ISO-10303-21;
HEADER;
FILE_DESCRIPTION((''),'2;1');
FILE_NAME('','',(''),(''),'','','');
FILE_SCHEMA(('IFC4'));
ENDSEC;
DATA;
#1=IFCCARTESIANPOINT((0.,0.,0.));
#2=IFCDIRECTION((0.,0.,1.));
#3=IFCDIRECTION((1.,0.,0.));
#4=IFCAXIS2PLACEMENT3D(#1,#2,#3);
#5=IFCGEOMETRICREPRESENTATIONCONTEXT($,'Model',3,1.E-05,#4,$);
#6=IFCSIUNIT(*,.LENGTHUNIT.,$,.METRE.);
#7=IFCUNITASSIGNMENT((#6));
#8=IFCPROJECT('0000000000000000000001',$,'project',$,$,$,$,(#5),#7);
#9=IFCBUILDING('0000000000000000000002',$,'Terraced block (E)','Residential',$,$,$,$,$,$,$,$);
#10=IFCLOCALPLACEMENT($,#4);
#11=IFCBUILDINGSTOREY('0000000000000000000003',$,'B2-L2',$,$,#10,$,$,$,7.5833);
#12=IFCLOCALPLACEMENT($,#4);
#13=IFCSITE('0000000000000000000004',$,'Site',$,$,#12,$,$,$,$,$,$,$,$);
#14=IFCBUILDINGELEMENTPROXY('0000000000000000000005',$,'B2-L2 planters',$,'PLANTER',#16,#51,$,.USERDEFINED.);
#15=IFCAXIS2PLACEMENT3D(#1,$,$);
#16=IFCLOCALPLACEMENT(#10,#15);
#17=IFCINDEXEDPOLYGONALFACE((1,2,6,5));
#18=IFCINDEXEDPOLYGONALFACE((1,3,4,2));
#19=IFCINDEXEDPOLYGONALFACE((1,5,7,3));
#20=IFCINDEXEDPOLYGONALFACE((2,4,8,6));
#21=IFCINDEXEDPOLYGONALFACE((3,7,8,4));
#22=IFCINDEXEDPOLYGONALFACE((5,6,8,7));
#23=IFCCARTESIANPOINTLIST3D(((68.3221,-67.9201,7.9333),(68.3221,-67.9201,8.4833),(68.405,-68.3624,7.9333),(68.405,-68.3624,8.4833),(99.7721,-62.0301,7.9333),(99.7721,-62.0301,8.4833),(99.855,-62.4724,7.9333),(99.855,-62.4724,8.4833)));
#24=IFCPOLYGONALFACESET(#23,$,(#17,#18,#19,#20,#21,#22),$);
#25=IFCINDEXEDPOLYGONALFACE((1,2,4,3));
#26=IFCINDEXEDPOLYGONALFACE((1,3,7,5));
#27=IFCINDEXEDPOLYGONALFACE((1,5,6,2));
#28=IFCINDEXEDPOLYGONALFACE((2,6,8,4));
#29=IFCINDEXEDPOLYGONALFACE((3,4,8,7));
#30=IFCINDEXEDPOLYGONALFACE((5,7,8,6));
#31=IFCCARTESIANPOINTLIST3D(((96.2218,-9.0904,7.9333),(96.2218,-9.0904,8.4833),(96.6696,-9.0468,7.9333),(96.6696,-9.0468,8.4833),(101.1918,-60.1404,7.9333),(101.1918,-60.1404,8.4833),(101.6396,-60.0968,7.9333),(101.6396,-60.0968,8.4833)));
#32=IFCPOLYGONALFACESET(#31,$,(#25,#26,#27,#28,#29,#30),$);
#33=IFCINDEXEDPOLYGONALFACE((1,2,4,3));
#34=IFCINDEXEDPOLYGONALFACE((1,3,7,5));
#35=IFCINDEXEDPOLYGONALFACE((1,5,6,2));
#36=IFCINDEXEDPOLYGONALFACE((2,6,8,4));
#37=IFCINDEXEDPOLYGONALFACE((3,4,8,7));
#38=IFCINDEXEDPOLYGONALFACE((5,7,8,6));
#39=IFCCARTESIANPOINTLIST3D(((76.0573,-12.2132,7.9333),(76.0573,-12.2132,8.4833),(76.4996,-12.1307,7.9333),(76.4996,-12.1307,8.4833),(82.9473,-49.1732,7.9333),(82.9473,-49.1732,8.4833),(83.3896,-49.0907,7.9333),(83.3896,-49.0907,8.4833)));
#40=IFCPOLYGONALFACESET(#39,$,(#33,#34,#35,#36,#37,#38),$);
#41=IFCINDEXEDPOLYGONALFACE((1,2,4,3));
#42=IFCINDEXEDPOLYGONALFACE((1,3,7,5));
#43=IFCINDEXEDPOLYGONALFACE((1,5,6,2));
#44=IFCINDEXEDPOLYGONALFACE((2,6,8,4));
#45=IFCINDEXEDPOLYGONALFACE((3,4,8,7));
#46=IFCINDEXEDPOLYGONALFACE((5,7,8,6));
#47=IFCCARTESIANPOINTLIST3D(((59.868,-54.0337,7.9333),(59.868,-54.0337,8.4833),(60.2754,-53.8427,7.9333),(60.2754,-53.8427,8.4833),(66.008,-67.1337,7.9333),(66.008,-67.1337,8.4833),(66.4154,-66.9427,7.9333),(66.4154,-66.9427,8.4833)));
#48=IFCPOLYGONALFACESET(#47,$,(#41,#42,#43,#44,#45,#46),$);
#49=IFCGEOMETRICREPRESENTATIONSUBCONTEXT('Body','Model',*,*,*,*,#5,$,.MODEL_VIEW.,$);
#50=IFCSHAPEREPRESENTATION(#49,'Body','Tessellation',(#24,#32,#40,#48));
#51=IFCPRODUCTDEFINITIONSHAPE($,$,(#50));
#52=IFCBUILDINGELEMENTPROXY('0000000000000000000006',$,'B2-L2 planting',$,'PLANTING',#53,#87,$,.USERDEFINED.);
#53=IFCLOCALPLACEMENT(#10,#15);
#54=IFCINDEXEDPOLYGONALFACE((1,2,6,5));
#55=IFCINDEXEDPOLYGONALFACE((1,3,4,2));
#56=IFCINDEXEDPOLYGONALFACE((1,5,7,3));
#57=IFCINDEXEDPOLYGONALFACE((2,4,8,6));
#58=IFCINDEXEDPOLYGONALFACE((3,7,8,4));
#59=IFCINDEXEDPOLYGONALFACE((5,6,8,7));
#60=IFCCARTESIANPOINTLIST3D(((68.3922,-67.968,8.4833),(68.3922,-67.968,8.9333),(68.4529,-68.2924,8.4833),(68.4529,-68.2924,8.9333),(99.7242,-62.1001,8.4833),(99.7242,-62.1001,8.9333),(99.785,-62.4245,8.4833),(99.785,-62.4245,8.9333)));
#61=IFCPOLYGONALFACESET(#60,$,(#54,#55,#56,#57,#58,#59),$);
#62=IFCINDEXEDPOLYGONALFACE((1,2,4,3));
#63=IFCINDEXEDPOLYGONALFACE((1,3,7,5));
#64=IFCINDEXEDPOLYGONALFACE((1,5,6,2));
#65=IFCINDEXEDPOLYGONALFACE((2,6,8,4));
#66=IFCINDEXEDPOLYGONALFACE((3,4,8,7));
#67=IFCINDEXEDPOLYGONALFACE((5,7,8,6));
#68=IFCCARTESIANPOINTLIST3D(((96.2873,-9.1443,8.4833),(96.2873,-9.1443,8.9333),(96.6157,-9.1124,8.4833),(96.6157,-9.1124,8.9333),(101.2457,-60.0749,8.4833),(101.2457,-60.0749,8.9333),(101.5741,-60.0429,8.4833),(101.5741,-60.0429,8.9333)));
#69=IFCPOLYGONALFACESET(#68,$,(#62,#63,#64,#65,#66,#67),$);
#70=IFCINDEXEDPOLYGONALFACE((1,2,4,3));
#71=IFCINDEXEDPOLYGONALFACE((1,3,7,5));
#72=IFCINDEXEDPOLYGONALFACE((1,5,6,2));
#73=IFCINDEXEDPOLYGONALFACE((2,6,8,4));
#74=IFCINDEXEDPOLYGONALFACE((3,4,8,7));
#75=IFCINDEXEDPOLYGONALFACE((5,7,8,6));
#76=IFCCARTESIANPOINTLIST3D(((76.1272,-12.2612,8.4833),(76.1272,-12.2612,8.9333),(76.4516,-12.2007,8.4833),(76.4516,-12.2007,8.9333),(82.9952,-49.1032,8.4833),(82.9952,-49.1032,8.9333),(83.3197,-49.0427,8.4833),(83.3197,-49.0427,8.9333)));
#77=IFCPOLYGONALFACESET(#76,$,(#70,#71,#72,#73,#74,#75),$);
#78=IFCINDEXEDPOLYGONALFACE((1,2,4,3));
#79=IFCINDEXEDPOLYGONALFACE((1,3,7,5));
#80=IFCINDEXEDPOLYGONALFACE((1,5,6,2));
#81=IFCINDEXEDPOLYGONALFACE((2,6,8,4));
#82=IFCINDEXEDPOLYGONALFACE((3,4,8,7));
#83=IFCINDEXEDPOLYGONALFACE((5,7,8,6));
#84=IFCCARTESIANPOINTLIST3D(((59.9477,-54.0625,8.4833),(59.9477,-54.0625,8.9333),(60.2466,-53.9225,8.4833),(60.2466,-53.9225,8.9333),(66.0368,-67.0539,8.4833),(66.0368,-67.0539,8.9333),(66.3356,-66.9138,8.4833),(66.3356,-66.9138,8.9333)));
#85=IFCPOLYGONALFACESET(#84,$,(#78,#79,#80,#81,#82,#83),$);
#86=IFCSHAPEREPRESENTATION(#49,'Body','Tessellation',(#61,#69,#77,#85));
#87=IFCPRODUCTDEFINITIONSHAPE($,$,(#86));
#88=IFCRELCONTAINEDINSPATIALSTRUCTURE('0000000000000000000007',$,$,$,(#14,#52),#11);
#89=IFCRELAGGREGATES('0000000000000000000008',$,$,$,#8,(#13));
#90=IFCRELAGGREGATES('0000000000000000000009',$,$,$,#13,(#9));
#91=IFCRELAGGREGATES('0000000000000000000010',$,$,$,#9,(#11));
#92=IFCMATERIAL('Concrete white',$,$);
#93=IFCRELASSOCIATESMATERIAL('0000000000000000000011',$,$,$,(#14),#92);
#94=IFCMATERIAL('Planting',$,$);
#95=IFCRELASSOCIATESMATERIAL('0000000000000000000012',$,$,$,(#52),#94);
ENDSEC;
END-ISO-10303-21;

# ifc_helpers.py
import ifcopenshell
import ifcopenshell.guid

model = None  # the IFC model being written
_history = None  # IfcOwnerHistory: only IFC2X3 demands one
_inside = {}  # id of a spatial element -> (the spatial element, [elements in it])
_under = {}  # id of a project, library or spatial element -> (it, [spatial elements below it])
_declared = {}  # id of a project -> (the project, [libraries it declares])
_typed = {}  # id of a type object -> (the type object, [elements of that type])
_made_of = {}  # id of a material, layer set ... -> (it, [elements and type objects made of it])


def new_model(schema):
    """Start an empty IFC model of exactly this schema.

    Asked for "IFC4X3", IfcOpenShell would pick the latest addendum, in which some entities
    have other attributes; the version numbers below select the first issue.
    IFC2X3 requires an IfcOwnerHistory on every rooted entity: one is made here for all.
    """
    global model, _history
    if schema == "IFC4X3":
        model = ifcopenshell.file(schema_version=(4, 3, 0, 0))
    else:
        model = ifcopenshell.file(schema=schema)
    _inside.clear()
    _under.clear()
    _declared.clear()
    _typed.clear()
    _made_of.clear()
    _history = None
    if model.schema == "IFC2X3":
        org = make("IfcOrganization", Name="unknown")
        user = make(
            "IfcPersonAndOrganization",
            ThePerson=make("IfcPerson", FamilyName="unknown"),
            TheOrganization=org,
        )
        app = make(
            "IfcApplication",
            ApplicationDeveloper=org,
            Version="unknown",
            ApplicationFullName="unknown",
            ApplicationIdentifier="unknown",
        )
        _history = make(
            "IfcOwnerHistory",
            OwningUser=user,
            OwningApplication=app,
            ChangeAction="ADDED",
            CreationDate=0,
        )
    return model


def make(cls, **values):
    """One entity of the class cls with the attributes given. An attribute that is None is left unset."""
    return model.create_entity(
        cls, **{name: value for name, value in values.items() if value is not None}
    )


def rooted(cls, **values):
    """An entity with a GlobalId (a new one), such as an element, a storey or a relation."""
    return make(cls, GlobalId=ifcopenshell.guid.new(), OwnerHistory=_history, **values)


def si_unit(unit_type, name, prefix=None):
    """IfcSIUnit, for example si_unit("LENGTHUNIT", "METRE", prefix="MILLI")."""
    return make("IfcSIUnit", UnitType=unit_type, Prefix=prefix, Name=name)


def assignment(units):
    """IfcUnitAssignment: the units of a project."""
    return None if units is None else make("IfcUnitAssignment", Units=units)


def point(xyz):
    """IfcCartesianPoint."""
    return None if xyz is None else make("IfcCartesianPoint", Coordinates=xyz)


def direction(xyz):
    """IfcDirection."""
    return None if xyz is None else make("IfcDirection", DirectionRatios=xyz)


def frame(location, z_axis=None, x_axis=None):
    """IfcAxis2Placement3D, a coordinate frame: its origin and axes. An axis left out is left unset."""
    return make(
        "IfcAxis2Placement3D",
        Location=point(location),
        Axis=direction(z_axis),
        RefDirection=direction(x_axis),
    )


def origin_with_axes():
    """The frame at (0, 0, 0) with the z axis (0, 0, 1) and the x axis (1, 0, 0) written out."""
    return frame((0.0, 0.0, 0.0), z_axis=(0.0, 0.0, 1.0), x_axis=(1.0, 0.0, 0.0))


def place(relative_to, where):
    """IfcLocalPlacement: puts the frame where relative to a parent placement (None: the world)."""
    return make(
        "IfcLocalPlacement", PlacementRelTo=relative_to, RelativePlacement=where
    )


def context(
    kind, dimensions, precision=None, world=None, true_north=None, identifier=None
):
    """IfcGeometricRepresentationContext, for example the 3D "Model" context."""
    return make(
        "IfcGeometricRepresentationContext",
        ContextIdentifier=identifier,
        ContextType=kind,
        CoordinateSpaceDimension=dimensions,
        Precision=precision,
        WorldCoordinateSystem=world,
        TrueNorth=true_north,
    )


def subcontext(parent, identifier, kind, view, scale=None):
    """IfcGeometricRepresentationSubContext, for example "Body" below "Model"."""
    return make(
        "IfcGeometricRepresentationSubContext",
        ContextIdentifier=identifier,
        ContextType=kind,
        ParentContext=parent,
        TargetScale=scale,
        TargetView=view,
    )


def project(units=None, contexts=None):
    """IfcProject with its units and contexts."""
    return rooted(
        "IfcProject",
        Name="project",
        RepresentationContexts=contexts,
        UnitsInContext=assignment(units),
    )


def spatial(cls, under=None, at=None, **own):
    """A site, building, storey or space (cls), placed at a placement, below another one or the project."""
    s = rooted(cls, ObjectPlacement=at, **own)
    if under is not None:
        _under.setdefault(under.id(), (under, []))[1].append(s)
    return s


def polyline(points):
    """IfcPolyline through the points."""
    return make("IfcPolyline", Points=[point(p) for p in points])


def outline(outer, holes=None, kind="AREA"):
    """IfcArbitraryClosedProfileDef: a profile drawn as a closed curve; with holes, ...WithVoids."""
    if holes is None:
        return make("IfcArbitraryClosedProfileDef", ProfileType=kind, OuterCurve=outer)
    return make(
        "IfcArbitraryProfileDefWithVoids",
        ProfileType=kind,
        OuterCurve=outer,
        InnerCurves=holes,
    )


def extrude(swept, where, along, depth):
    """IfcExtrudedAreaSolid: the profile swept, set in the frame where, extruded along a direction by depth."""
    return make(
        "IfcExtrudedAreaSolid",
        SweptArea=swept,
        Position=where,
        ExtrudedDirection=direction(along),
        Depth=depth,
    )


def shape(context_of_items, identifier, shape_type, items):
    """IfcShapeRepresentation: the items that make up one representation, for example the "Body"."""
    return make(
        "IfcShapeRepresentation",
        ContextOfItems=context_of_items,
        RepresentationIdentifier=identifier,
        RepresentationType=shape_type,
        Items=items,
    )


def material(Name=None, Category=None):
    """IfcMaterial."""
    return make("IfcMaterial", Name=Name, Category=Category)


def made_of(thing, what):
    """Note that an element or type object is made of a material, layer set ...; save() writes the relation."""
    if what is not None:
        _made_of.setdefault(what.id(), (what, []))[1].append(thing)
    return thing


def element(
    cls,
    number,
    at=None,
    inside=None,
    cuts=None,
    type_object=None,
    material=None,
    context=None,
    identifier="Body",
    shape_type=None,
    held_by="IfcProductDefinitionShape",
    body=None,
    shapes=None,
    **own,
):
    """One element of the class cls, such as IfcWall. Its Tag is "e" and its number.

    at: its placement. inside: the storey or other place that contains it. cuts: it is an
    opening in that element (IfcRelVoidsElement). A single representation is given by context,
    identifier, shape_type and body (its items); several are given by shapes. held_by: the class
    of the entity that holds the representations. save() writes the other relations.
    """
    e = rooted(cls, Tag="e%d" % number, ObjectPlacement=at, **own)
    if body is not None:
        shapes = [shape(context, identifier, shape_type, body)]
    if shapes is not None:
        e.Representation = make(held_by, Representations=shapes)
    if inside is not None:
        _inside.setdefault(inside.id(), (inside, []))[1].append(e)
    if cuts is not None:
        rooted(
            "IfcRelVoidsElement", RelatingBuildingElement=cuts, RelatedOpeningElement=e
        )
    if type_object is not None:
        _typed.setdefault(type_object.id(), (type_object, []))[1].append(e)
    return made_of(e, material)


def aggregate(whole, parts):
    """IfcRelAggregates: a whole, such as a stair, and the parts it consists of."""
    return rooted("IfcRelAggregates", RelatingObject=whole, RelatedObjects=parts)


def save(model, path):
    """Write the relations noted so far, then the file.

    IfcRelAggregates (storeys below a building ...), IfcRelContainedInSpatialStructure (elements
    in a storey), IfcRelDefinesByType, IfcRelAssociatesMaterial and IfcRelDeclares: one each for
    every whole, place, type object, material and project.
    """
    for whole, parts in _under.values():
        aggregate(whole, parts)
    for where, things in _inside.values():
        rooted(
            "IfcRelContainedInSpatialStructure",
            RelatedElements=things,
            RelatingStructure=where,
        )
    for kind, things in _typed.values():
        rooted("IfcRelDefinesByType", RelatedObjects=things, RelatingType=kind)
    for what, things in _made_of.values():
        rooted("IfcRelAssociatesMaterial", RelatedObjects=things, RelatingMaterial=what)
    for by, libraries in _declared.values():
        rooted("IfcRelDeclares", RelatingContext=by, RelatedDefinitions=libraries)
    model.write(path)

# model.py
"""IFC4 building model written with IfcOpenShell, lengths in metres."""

from ifc_helpers import new_model, si_unit, frame, origin_with_axes, place, context, subcontext, project, spatial, polyline, outline, extrude, material, element, save


model = new_model("IFC4")

# Units and contexts
model_context = context("Model", 3, precision=1e-05, world=origin_with_axes())
body_context = subcontext(model_context, "Body", "Model", "MODEL_VIEW")
ifc_project = project(units=[si_unit("LENGTHUNIT", "METRE")], contexts=[model_context])

# Site, building, storey
site_placement = place(None, origin_with_axes())
site = spatial("IfcSite", under=ifc_project, at=site_placement, Name="Site")
building = spatial("IfcBuilding", under=site, Name="Terraced block (E)", Description="Residential")
storey_placement = place(None, origin_with_axes())
storey = spatial("IfcBuildingStorey", under=building, at=storey_placement, Name="B2-L2", Elevation=7.5833)

# Shared definitions
ifc_material_1 = material(Name="Concrete white")

# Building element proxies
proxy_1_placement = place(storey_placement, origin_with_axes())
element("IfcBuildingElementProxy", 1, at=proxy_1_placement, inside=storey, material=ifc_material_1, Name="B2-L2 planters", ObjectType="PLANTER", PredefinedType="USERDEFINED", context=body_context, shape_type="SweptSolid", body=[
    extrude(outline(polyline([(68.405, -68.3624), (99.855, -62.4724), (99.7721, -62.0301), (68.3221, -67.9201), (68.405, -68.3624)])), frame((0.0, 0.0, 7.9333), z_axis=(0.0, 0.0, 1.0), x_axis=(1.0, 0.0, 0.0)), (0.0, 0.0, 1.0), 0.55),
    extrude(outline(polyline([(101.6396, -60.0968), (96.6696, -9.0468), (96.2218, -9.0904), (101.1918, -60.1404), (101.6396, -60.0968)])), frame((0.0, 0.0, 7.9333), z_axis=(0.0, 0.0, 1.0), x_axis=(1.0, 0.0, 0.0)), (0.0, 0.0, 1.0), 0.55),
    extrude(outline(polyline([(76.0573, -12.2132), (82.9473, -49.1732), (83.3896, -49.0907), (76.4996, -12.1307), (76.0573, -12.2132)])), frame((0.0, 0.0, 7.9333), z_axis=(0.0, 0.0, 1.0), x_axis=(1.0, 0.0, 0.0)), (0.0, 0.0, 1.0), 0.55),
    extrude(outline(polyline([(59.868, -54.0337), (66.008, -67.1337), (66.4154, -66.9427), (60.2754, -53.8427), (59.868, -54.0337)])), frame((0.0, 0.0, 7.9333), z_axis=(0.0, 0.0, 1.0), x_axis=(1.0, 0.0, 0.0)), (0.0, 0.0, 1.0), 0.55),
])
ifc_material_2 = material(Name="Planting")
proxy_2_placement = place(storey_placement, origin_with_axes())
element("IfcBuildingElementProxy", 2, at=proxy_2_placement, inside=storey, material=ifc_material_2, Name="B2-L2 planting", ObjectType="PLANTING", PredefinedType="USERDEFINED", context=body_context, shape_type="SweptSolid", body=[
    extrude(outline(polyline([(68.4529, -68.2924), (99.785, -62.4245), (99.7242, -62.1001), (68.3922, -67.968), (68.4529, -68.2924)])), frame((0.0, 0.0, 8.4833), z_axis=(0.0, 0.0, 1.0), x_axis=(1.0, 0.0, 0.0)), (0.0, 0.0, 1.0), 0.45),
    extrude(outline(polyline([(101.5741, -60.0429), (96.6157, -9.1124), (96.2873, -9.1443), (101.2457, -60.0749), (101.5741, -60.0429)])), frame((0.0, 0.0, 8.4833), z_axis=(0.0, 0.0, 1.0), x_axis=(1.0, 0.0, 0.0)), (0.0, 0.0, 1.0), 0.45),
    extrude(outline(polyline([(76.1272, -12.2612), (82.9952, -49.1032), (83.3197, -49.0427), (76.4516, -12.2007), (76.1272, -12.2612)])), frame((0.0, 0.0, 8.4833), z_axis=(0.0, 0.0, 1.0), x_axis=(1.0, 0.0, 0.0)), (0.0, 0.0, 1.0), 0.45),
    extrude(outline(polyline([(59.9477, -54.0625), (66.0368, -67.0539), (66.3356, -66.9138), (60.2466, -53.9225), (59.9477, -54.0625)])), frame((0.0, 0.0, 8.4833), z_axis=(0.0, 0.0, 1.0), x_axis=(1.0, 0.0, 0.0)), (0.0, 0.0, 1.0), 0.45),
])

save(model, "model.ifc")
